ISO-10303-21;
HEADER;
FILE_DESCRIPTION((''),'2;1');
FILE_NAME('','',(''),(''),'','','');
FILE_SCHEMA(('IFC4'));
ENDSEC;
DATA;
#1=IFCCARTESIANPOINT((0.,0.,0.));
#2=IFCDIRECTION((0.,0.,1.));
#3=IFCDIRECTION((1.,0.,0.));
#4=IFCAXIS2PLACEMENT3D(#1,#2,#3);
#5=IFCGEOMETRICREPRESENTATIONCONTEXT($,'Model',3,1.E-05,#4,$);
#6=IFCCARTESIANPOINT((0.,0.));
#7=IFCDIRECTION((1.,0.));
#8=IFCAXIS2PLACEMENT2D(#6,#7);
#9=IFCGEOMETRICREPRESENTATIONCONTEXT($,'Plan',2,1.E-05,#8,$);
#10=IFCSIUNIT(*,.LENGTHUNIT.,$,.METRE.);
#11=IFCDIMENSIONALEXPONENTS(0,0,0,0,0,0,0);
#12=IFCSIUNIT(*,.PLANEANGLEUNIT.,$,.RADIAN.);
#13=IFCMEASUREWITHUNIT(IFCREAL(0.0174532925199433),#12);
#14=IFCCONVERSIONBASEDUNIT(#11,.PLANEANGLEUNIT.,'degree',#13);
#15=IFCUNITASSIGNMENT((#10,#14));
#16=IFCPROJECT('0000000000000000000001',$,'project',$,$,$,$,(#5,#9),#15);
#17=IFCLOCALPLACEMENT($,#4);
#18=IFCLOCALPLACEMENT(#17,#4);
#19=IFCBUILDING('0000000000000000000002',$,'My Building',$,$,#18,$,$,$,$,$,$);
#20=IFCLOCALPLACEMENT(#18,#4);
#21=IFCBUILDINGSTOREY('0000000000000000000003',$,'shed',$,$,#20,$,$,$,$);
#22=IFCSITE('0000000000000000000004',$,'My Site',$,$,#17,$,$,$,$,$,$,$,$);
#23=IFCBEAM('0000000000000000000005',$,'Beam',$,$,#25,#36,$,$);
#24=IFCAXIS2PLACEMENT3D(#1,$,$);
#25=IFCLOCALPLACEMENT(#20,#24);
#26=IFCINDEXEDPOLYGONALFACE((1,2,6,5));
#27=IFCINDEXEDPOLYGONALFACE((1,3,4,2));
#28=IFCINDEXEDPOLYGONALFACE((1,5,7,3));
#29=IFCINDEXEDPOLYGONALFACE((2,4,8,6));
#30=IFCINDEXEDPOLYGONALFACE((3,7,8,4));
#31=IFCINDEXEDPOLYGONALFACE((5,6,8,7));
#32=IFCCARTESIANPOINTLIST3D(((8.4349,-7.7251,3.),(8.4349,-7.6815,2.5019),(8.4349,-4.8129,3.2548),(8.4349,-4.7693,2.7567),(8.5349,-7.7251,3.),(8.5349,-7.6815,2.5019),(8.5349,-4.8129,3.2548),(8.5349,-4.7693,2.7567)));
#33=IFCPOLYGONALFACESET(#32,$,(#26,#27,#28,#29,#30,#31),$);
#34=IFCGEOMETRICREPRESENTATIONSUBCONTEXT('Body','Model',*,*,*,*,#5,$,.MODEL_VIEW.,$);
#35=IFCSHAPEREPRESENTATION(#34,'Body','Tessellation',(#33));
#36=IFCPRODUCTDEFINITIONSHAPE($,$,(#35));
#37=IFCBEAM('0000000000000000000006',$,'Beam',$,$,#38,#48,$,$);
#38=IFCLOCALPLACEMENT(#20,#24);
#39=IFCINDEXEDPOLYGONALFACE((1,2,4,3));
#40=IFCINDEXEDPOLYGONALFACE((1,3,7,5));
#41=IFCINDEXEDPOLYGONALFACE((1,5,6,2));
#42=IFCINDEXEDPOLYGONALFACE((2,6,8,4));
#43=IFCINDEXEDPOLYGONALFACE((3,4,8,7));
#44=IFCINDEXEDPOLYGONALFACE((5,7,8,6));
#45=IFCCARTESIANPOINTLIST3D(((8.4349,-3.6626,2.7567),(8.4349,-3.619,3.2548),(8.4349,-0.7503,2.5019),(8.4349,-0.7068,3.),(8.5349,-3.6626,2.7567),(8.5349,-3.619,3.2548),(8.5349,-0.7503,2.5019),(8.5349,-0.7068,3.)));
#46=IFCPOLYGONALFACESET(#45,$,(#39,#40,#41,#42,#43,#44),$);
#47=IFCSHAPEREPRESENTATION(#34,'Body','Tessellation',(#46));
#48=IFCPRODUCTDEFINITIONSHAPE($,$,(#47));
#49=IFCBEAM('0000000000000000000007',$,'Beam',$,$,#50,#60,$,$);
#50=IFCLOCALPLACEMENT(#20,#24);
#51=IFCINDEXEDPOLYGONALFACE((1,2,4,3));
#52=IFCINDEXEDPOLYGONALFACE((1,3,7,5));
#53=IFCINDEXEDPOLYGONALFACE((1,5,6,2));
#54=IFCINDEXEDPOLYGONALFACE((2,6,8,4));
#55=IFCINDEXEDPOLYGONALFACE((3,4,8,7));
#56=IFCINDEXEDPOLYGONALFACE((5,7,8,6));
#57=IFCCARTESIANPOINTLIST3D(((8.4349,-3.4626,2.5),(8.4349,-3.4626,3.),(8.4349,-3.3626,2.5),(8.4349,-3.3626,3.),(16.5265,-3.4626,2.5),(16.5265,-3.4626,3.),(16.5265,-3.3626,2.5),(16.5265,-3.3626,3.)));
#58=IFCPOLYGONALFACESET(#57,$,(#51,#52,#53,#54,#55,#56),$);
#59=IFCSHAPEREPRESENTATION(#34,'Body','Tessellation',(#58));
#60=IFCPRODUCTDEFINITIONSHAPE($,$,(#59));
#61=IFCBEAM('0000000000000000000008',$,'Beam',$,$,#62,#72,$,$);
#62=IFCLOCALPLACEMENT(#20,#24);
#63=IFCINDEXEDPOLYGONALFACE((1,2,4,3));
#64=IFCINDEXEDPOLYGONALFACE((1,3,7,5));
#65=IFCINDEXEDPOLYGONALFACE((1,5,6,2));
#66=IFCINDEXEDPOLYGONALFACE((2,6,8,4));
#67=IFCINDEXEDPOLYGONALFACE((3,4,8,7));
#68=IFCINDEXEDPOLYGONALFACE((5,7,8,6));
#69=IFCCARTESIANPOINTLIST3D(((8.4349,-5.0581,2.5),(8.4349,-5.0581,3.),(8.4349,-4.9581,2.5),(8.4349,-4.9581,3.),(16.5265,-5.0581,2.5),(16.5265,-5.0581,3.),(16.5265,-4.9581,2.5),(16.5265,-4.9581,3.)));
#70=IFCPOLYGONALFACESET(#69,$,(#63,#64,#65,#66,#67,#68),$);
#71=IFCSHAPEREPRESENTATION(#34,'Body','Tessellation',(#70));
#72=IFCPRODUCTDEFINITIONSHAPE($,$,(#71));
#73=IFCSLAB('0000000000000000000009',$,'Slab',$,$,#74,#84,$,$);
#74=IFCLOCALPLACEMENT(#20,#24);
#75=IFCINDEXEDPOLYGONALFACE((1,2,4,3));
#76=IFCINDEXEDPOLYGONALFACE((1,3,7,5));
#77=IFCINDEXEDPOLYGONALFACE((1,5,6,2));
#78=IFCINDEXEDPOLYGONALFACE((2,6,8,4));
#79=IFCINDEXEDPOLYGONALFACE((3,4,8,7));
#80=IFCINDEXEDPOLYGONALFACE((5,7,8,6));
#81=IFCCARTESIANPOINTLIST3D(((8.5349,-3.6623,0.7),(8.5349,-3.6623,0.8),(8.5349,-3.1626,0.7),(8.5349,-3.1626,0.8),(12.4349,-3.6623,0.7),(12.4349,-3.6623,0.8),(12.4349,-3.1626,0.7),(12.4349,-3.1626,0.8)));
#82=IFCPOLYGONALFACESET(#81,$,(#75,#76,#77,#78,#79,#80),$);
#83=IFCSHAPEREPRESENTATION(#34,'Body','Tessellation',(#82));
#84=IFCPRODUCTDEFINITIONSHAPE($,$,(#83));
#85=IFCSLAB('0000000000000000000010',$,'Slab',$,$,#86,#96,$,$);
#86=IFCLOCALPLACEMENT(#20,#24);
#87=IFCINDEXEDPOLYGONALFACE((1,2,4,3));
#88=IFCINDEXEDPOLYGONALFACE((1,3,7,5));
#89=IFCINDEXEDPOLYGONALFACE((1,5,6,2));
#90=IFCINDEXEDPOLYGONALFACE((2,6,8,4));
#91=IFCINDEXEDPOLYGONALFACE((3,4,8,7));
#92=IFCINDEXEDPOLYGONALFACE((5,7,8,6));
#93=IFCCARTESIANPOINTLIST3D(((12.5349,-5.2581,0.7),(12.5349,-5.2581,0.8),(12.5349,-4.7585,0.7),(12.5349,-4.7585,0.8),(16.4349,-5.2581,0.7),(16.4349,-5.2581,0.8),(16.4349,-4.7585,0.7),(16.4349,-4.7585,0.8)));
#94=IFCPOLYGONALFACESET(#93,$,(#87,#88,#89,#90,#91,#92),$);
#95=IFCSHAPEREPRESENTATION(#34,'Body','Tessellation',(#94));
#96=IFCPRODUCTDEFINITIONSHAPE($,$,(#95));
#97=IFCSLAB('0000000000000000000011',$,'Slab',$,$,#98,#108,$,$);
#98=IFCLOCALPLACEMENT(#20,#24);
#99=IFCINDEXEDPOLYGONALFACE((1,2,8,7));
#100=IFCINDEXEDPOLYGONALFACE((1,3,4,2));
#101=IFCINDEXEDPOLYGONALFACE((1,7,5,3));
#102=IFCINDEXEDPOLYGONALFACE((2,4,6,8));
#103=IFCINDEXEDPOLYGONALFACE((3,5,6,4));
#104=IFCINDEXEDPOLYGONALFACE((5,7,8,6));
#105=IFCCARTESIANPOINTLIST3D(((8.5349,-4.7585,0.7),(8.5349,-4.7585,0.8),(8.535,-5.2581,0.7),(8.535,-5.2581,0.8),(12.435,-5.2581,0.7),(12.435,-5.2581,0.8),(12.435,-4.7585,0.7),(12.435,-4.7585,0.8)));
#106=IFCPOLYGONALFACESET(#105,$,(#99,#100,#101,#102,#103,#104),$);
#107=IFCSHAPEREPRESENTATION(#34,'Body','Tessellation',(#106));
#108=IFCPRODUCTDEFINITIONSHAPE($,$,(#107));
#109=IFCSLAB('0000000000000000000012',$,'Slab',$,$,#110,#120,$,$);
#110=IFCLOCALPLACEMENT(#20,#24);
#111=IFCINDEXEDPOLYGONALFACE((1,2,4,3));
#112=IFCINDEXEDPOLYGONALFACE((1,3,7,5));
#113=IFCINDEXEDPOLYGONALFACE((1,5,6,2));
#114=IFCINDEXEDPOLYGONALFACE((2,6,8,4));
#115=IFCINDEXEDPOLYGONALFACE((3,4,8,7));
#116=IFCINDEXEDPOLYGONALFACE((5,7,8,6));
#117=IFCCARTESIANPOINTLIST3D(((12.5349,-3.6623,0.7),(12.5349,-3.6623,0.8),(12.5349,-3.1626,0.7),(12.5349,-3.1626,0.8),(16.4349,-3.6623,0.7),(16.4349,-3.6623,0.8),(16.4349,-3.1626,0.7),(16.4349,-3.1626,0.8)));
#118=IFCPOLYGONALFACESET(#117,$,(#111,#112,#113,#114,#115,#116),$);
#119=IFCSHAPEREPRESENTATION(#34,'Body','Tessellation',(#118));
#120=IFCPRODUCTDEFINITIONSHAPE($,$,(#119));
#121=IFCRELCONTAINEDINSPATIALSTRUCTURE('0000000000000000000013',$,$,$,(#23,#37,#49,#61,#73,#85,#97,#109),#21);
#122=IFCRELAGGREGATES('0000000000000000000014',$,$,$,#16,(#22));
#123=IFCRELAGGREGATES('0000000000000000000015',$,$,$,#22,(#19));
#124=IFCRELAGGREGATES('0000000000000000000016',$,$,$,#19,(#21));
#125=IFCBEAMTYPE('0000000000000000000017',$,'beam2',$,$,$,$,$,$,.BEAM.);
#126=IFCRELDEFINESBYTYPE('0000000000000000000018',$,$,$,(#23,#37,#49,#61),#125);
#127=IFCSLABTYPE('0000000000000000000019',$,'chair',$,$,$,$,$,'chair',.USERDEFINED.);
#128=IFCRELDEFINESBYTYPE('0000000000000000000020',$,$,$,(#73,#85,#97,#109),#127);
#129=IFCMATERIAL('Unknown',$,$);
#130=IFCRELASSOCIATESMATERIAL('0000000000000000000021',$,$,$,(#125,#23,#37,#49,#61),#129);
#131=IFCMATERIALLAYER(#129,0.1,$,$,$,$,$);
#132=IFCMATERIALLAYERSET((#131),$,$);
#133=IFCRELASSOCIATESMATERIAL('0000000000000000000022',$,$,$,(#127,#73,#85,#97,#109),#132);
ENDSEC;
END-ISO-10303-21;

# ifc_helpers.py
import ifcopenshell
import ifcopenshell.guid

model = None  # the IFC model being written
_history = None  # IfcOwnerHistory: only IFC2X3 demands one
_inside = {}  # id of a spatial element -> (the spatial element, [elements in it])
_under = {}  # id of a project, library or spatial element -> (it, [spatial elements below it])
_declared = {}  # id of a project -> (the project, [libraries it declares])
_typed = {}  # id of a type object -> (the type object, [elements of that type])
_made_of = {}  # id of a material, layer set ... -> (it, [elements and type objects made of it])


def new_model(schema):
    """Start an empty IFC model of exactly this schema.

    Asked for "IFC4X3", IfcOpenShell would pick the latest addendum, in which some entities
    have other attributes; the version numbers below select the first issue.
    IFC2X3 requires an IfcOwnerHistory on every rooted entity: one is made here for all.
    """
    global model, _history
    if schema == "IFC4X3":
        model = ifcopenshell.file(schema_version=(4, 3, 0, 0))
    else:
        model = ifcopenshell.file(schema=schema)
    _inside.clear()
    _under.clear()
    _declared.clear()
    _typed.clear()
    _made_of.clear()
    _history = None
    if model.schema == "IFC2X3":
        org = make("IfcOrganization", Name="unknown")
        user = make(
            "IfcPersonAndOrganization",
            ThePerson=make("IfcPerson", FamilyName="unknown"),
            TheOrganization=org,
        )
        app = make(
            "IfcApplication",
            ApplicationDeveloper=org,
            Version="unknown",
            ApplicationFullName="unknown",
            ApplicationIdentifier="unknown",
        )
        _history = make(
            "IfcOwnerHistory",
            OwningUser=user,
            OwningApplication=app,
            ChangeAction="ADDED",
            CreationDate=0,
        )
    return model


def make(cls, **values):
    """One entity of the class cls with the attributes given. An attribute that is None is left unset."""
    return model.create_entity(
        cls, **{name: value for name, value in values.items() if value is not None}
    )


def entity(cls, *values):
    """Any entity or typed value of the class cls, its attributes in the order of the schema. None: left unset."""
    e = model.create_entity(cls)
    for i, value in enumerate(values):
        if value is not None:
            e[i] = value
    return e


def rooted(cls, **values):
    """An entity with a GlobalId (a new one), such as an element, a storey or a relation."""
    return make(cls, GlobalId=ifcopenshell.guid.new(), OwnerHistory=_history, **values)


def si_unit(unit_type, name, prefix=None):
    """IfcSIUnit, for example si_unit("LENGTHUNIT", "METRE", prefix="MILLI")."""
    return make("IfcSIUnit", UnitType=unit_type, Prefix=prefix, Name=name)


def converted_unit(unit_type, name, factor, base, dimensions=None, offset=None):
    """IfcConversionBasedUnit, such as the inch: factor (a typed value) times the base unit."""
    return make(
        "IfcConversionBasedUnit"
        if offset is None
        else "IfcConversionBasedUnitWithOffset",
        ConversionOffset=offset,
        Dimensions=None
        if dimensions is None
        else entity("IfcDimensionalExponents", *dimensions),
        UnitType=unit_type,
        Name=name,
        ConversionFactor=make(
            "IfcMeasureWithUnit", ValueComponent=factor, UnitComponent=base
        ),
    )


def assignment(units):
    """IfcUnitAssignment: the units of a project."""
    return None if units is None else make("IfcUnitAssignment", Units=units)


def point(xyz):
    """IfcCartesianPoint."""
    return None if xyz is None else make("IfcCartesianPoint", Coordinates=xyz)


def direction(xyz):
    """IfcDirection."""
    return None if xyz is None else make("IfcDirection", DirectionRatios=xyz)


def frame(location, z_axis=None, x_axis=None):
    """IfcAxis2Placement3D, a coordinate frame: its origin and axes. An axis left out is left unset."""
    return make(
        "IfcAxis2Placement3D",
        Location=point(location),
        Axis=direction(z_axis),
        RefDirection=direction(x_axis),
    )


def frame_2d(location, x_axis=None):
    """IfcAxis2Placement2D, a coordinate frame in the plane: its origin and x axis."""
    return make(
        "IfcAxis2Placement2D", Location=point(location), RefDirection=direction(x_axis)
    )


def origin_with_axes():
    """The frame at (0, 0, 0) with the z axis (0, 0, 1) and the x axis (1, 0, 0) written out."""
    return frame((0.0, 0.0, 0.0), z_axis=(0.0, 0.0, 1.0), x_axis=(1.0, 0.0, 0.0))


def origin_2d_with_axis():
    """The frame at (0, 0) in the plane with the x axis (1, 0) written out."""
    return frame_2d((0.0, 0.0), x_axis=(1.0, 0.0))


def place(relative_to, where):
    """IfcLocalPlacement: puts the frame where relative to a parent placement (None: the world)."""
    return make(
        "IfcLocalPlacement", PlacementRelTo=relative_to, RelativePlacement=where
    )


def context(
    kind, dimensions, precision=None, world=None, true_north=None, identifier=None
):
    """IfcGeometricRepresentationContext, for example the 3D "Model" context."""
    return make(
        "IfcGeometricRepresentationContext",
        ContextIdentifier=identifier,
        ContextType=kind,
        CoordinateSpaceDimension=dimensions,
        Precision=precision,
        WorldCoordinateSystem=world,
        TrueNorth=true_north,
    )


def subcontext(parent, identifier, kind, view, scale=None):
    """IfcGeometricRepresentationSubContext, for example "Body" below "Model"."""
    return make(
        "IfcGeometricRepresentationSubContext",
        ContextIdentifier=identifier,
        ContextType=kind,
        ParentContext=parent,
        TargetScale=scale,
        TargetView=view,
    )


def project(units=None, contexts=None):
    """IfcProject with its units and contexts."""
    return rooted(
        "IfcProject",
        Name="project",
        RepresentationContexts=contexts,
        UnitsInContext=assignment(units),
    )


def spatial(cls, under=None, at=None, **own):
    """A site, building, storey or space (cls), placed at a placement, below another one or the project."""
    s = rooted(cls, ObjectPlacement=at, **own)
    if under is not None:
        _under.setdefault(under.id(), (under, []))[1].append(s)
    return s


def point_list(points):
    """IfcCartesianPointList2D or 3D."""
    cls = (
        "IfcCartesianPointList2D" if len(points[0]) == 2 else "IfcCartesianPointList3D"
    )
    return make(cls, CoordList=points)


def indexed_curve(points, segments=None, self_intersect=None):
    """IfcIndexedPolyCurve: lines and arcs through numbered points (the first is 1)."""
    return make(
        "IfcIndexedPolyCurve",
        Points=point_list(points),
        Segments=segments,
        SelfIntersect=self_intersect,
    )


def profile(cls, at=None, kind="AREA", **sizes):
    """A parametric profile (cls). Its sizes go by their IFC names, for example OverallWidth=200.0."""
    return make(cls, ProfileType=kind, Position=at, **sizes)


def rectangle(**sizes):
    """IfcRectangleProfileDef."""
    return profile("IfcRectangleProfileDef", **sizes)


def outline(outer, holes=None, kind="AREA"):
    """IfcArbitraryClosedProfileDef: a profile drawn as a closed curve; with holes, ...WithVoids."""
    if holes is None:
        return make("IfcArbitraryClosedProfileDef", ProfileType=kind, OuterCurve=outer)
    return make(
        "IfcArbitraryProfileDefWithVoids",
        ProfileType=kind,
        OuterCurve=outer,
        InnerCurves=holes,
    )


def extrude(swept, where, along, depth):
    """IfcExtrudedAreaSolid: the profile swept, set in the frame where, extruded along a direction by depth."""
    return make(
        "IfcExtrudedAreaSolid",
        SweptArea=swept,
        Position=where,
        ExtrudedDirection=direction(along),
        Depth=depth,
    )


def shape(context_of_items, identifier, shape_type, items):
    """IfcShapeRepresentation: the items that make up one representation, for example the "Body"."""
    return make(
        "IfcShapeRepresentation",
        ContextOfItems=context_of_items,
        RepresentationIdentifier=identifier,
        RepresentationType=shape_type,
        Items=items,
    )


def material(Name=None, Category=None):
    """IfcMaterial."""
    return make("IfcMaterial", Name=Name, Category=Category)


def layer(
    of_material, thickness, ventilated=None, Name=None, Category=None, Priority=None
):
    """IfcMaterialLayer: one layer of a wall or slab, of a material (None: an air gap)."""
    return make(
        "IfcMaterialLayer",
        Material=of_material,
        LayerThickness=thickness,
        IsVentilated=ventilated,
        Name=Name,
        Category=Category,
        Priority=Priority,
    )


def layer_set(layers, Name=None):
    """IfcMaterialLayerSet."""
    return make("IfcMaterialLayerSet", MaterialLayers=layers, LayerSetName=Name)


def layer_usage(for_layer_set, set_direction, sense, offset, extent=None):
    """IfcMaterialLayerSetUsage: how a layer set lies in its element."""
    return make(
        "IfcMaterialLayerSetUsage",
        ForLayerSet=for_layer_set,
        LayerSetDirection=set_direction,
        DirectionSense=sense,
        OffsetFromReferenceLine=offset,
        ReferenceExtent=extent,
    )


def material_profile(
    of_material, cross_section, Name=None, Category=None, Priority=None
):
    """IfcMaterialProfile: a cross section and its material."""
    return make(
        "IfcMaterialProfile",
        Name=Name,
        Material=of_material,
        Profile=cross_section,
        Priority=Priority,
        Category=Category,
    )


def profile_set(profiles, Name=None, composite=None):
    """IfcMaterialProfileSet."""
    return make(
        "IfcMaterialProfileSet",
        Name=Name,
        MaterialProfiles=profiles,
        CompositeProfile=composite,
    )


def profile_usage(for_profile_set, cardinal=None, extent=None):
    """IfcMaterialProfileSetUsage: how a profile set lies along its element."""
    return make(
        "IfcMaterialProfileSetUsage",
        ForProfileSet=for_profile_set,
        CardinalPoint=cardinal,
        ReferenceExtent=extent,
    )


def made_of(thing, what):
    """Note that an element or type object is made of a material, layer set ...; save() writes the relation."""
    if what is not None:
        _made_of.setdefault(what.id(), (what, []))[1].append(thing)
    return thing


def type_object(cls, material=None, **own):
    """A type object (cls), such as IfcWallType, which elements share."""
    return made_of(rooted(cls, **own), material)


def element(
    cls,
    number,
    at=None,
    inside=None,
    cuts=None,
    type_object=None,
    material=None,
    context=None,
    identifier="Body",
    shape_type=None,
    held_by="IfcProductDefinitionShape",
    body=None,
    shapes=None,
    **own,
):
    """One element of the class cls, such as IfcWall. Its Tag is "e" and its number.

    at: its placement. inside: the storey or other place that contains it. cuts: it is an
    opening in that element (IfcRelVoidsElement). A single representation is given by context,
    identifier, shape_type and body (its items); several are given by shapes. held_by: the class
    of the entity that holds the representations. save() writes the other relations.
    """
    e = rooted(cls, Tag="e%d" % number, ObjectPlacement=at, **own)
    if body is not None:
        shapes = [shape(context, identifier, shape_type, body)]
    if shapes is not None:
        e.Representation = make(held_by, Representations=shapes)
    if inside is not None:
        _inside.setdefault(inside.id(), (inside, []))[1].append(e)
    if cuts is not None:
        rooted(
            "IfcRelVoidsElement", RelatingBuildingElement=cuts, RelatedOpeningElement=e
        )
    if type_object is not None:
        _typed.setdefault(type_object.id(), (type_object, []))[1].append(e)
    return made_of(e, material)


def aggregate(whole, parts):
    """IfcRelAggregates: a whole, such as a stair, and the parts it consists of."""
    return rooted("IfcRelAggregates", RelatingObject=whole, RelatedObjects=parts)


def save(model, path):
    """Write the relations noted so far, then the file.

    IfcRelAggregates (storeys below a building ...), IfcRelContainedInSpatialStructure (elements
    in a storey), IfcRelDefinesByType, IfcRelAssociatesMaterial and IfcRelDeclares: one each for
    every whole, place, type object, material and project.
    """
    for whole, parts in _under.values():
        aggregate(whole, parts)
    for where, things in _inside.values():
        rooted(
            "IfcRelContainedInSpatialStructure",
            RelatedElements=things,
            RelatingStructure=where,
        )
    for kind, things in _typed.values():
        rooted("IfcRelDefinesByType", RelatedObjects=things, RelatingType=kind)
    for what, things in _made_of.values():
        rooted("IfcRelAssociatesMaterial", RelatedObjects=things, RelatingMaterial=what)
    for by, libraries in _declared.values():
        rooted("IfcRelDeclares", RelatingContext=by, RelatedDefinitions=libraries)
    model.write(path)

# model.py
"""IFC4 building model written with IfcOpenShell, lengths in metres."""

from ifc_helpers import new_model, entity, si_unit, converted_unit, frame, origin_with_axes, origin_2d_with_axis, place, context, subcontext, project, spatial, indexed_curve, rectangle, outline, extrude, material, layer, layer_set, layer_usage, material_profile, profile_set, profile_usage, type_object, element, save


model = new_model("IFC4")

# Units and contexts
model_context = context("Model", 3, precision=1e-05, world=origin_with_axes())
plan_context = context("Plan", 2, precision=1e-05, world=origin_2d_with_axis())
body_context = subcontext(model_context, "Body", "Model", "MODEL_VIEW")
ifc_project = project(units=[si_unit("LENGTHUNIT", "METRE"), converted_unit("PLANEANGLEUNIT", "degree", entity("IfcReal", 0.0174532925199433), si_unit("PLANEANGLEUNIT", "RADIAN"), dimensions=[0, 0, 0, 0, 0, 0, 0])], contexts=[model_context, plan_context])

# Site, building, storey
site_placement = place(None, origin_with_axes())
site = spatial("IfcSite", under=ifc_project, at=site_placement, Name="My Site")
building_placement = place(site_placement, origin_with_axes())
building = spatial("IfcBuilding", under=site, at=building_placement, Name="My Building")
storey_placement = place(building_placement, origin_with_axes())
storey = spatial("IfcBuildingStorey", under=building, at=storey_placement, Name="shed")

# Shared definitions
ifc_material = material(Name="Unknown")

# Beams
ifc_material_profile_1 = material_profile(ifc_material, rectangle(XDim=0.1, YDim=0.5))
ifc_profile_set_1 = profile_set([ifc_material_profile_1])
beam_type = type_object("IfcBeamType", Name="beam2", PredefinedType="BEAM", material=ifc_profile_set_1)
ifc_profile_usage_1 = profile_usage(ifc_profile_set_1, cardinal=8)
beam_1_placement = place(storey_placement, frame((8.4849, -7.7251, 3.0), z_axis=(0.0, 0.996195, 0.087156), x_axis=(-1.0, 0.0, 0.0)))
element("IfcBeam", 1, at=beam_1_placement, inside=storey, type_object=beam_type, material=ifc_profile_usage_1, Name="Beam", context=body_context, shape_type="SweptSolid", body=[
    extrude(rectangle(XDim=0.1, YDim=0.5), frame((0.0, -0.25, 0.0), z_axis=(0.0, 0.0, 1.0), x_axis=(1.0, 0.0, 0.0)), (0.0, 0.0, 1.0), 2.9234),
])
ifc_profile_usage_2 = profile_usage(ifc_profile_set_1, cardinal=8)
beam_2_placement = place(storey_placement, frame((8.4849, -0.7068, 3.0), z_axis=(0.0, -0.996195, 0.087156), x_axis=(1.0, 0.0, 0.0)))
element("IfcBeam", 2, at=beam_2_placement, inside=storey, type_object=beam_type, material=ifc_profile_usage_2, Name="Beam", context=body_context, shape_type="SweptSolid", body=[
    extrude(rectangle(XDim=0.1, YDim=0.5), frame((0.0, -0.25, 0.0), z_axis=(0.0, 0.0, 1.0), x_axis=(1.0, 0.0, 0.0)), (0.0, 0.0, 1.0), 2.9234),
])
ifc_profile_usage_3 = profile_usage(ifc_profile_set_1, cardinal=8)
beam_3_placement = place(storey_placement, frame((8.4349, -3.4126, 3.0), z_axis=(1.0, -0.000001, 0.000001), x_axis=(0.000001, 1.0, 0.0)))
element("IfcBeam", 3, at=beam_3_placement, inside=storey, type_object=beam_type, material=ifc_profile_usage_3, Name="Beam", context=body_context, shape_type="SweptSolid", body=[
    extrude(rectangle(XDim=0.1, YDim=0.5), frame((0.0, -0.25, 0.0), z_axis=(0.0, 0.0, 1.0), x_axis=(1.0, 0.0, 0.0)), (0.0, 0.0, 1.0), 8.0916),
])
ifc_profile_usage_4 = profile_usage(ifc_profile_set_1, cardinal=8)
beam_4_placement = place(storey_placement, frame((8.4349, -5.0081, 3.0), z_axis=(1.0, -0.000001, 0.000001), x_axis=(0.000001, 1.0, 0.0)))
element("IfcBeam", 4, at=beam_4_placement, inside=storey, type_object=beam_type, material=ifc_profile_usage_4, Name="Beam", context=body_context, shape_type="SweptSolid", body=[
    extrude(rectangle(XDim=0.1, YDim=0.5), frame((0.0, -0.25, 0.0), z_axis=(0.0, 0.0, 1.0), x_axis=(1.0, 0.0, 0.0)), (0.0, 0.0, 1.0), 8.0916),
])

# Slabs
ifc_layer = layer(ifc_material, 0.1)
ifc_layer_set = layer_set([ifc_layer])
ifc_layer_usage_1 = layer_usage(ifc_layer_set, "AXIS3", "POSITIVE", -0.1)
slab_type = type_object("IfcSlabType", Name="chair", ElementType="chair", PredefinedType="USERDEFINED", material=ifc_layer_set)
slab_1_placement = place(storey_placement, frame((8.5349, -3.6623, 0.8), z_axis=(0.0, 0.0, 1.0), x_axis=(1.0, 0.0, 0.0)))
element("IfcSlab", 5, at=slab_1_placement, inside=storey, type_object=slab_type, material=ifc_layer_usage_1, Name="Slab", context=body_context, shape_type="SweptSolid", body=[
    extrude(outline(indexed_curve([(0.0, 0.0), (3.9, 0.0), (3.9, 0.4997), (0.0, 0.4997), (0.0, 0.0)])), frame((0.0, 0.0, -0.1), z_axis=(0.0, 0.0, 1.0), x_axis=(1.0, 0.0, 0.0)), (0.0, 0.0, 1.0), 0.1),
])
ifc_layer_usage_2 = layer_usage(ifc_layer_set, "AXIS3", "POSITIVE", -0.1)
slab_2_placement = place(storey_placement, frame((12.5349, -5.2581, 0.8), z_axis=(0.0, 0.0, 1.0), x_axis=(1.0, 0.0, 0.0)))
element("IfcSlab", 6, at=slab_2_placement, inside=storey, type_object=slab_type, material=ifc_layer_usage_2, Name="Slab", context=body_context, shape_type="SweptSolid", body=[
    extrude(outline(indexed_curve([(0.0, 0.0), (3.9, 0.0), (3.9, 0.4997), (0.0, 0.4997), (0.0, 0.0)])), frame((0.0, 0.0, -0.1), z_axis=(0.0, 0.0, 1.0), x_axis=(1.0, 0.0, 0.0)), (0.0, 0.0, 1.0), 0.1),
])
ifc_layer_usage_3 = layer_usage(ifc_layer_set, "AXIS3", "POSITIVE", -0.1)
slab_3_placement = place(storey_placement, frame((8.535, -5.2581, 0.8), z_axis=(0.0, 0.0, 1.0), x_axis=(1.0, 0.0, 0.0)))
element("IfcSlab", 7, at=slab_3_placement, inside=storey, type_object=slab_type, material=ifc_layer_usage_3, Name="Slab", context=body_context, shape_type="SweptSolid", body=[
    extrude(outline(indexed_curve([(0.0, 0.0), (3.9, 0.0), (3.9, 0.4997), (0.0, 0.4997), (0.0, 0.0)])), frame((0.0, 0.0, -0.1), z_axis=(0.0, 0.0, 1.0), x_axis=(1.0, 0.0, 0.0)), (0.0, 0.0, 1.0), 0.1),
])
ifc_layer_usage_4 = layer_usage(ifc_layer_set, "AXIS3", "POSITIVE", -0.1)
slab_4_placement = place(storey_placement, frame((12.5349, -3.6623, 0.8), z_axis=(0.0, 0.0, 1.0), x_axis=(1.0, 0.0, 0.0)))
element("IfcSlab", 8, at=slab_4_placement, inside=storey, type_object=slab_type, material=ifc_layer_usage_4, Name="Slab", context=body_context, shape_type="SweptSolid", body=[
    extrude(outline(indexed_curve([(0.0, 0.0), (3.9, 0.0), (3.9, 0.4997), (0.0, 0.4997), (0.0, 0.0)])), frame((0.0, 0.0, -0.1), z_axis=(0.0, 0.0, 1.0), x_axis=(1.0, 0.0, 0.0)), (0.0, 0.0, 1.0), 0.1),
])

save(model, "model.ifc")
